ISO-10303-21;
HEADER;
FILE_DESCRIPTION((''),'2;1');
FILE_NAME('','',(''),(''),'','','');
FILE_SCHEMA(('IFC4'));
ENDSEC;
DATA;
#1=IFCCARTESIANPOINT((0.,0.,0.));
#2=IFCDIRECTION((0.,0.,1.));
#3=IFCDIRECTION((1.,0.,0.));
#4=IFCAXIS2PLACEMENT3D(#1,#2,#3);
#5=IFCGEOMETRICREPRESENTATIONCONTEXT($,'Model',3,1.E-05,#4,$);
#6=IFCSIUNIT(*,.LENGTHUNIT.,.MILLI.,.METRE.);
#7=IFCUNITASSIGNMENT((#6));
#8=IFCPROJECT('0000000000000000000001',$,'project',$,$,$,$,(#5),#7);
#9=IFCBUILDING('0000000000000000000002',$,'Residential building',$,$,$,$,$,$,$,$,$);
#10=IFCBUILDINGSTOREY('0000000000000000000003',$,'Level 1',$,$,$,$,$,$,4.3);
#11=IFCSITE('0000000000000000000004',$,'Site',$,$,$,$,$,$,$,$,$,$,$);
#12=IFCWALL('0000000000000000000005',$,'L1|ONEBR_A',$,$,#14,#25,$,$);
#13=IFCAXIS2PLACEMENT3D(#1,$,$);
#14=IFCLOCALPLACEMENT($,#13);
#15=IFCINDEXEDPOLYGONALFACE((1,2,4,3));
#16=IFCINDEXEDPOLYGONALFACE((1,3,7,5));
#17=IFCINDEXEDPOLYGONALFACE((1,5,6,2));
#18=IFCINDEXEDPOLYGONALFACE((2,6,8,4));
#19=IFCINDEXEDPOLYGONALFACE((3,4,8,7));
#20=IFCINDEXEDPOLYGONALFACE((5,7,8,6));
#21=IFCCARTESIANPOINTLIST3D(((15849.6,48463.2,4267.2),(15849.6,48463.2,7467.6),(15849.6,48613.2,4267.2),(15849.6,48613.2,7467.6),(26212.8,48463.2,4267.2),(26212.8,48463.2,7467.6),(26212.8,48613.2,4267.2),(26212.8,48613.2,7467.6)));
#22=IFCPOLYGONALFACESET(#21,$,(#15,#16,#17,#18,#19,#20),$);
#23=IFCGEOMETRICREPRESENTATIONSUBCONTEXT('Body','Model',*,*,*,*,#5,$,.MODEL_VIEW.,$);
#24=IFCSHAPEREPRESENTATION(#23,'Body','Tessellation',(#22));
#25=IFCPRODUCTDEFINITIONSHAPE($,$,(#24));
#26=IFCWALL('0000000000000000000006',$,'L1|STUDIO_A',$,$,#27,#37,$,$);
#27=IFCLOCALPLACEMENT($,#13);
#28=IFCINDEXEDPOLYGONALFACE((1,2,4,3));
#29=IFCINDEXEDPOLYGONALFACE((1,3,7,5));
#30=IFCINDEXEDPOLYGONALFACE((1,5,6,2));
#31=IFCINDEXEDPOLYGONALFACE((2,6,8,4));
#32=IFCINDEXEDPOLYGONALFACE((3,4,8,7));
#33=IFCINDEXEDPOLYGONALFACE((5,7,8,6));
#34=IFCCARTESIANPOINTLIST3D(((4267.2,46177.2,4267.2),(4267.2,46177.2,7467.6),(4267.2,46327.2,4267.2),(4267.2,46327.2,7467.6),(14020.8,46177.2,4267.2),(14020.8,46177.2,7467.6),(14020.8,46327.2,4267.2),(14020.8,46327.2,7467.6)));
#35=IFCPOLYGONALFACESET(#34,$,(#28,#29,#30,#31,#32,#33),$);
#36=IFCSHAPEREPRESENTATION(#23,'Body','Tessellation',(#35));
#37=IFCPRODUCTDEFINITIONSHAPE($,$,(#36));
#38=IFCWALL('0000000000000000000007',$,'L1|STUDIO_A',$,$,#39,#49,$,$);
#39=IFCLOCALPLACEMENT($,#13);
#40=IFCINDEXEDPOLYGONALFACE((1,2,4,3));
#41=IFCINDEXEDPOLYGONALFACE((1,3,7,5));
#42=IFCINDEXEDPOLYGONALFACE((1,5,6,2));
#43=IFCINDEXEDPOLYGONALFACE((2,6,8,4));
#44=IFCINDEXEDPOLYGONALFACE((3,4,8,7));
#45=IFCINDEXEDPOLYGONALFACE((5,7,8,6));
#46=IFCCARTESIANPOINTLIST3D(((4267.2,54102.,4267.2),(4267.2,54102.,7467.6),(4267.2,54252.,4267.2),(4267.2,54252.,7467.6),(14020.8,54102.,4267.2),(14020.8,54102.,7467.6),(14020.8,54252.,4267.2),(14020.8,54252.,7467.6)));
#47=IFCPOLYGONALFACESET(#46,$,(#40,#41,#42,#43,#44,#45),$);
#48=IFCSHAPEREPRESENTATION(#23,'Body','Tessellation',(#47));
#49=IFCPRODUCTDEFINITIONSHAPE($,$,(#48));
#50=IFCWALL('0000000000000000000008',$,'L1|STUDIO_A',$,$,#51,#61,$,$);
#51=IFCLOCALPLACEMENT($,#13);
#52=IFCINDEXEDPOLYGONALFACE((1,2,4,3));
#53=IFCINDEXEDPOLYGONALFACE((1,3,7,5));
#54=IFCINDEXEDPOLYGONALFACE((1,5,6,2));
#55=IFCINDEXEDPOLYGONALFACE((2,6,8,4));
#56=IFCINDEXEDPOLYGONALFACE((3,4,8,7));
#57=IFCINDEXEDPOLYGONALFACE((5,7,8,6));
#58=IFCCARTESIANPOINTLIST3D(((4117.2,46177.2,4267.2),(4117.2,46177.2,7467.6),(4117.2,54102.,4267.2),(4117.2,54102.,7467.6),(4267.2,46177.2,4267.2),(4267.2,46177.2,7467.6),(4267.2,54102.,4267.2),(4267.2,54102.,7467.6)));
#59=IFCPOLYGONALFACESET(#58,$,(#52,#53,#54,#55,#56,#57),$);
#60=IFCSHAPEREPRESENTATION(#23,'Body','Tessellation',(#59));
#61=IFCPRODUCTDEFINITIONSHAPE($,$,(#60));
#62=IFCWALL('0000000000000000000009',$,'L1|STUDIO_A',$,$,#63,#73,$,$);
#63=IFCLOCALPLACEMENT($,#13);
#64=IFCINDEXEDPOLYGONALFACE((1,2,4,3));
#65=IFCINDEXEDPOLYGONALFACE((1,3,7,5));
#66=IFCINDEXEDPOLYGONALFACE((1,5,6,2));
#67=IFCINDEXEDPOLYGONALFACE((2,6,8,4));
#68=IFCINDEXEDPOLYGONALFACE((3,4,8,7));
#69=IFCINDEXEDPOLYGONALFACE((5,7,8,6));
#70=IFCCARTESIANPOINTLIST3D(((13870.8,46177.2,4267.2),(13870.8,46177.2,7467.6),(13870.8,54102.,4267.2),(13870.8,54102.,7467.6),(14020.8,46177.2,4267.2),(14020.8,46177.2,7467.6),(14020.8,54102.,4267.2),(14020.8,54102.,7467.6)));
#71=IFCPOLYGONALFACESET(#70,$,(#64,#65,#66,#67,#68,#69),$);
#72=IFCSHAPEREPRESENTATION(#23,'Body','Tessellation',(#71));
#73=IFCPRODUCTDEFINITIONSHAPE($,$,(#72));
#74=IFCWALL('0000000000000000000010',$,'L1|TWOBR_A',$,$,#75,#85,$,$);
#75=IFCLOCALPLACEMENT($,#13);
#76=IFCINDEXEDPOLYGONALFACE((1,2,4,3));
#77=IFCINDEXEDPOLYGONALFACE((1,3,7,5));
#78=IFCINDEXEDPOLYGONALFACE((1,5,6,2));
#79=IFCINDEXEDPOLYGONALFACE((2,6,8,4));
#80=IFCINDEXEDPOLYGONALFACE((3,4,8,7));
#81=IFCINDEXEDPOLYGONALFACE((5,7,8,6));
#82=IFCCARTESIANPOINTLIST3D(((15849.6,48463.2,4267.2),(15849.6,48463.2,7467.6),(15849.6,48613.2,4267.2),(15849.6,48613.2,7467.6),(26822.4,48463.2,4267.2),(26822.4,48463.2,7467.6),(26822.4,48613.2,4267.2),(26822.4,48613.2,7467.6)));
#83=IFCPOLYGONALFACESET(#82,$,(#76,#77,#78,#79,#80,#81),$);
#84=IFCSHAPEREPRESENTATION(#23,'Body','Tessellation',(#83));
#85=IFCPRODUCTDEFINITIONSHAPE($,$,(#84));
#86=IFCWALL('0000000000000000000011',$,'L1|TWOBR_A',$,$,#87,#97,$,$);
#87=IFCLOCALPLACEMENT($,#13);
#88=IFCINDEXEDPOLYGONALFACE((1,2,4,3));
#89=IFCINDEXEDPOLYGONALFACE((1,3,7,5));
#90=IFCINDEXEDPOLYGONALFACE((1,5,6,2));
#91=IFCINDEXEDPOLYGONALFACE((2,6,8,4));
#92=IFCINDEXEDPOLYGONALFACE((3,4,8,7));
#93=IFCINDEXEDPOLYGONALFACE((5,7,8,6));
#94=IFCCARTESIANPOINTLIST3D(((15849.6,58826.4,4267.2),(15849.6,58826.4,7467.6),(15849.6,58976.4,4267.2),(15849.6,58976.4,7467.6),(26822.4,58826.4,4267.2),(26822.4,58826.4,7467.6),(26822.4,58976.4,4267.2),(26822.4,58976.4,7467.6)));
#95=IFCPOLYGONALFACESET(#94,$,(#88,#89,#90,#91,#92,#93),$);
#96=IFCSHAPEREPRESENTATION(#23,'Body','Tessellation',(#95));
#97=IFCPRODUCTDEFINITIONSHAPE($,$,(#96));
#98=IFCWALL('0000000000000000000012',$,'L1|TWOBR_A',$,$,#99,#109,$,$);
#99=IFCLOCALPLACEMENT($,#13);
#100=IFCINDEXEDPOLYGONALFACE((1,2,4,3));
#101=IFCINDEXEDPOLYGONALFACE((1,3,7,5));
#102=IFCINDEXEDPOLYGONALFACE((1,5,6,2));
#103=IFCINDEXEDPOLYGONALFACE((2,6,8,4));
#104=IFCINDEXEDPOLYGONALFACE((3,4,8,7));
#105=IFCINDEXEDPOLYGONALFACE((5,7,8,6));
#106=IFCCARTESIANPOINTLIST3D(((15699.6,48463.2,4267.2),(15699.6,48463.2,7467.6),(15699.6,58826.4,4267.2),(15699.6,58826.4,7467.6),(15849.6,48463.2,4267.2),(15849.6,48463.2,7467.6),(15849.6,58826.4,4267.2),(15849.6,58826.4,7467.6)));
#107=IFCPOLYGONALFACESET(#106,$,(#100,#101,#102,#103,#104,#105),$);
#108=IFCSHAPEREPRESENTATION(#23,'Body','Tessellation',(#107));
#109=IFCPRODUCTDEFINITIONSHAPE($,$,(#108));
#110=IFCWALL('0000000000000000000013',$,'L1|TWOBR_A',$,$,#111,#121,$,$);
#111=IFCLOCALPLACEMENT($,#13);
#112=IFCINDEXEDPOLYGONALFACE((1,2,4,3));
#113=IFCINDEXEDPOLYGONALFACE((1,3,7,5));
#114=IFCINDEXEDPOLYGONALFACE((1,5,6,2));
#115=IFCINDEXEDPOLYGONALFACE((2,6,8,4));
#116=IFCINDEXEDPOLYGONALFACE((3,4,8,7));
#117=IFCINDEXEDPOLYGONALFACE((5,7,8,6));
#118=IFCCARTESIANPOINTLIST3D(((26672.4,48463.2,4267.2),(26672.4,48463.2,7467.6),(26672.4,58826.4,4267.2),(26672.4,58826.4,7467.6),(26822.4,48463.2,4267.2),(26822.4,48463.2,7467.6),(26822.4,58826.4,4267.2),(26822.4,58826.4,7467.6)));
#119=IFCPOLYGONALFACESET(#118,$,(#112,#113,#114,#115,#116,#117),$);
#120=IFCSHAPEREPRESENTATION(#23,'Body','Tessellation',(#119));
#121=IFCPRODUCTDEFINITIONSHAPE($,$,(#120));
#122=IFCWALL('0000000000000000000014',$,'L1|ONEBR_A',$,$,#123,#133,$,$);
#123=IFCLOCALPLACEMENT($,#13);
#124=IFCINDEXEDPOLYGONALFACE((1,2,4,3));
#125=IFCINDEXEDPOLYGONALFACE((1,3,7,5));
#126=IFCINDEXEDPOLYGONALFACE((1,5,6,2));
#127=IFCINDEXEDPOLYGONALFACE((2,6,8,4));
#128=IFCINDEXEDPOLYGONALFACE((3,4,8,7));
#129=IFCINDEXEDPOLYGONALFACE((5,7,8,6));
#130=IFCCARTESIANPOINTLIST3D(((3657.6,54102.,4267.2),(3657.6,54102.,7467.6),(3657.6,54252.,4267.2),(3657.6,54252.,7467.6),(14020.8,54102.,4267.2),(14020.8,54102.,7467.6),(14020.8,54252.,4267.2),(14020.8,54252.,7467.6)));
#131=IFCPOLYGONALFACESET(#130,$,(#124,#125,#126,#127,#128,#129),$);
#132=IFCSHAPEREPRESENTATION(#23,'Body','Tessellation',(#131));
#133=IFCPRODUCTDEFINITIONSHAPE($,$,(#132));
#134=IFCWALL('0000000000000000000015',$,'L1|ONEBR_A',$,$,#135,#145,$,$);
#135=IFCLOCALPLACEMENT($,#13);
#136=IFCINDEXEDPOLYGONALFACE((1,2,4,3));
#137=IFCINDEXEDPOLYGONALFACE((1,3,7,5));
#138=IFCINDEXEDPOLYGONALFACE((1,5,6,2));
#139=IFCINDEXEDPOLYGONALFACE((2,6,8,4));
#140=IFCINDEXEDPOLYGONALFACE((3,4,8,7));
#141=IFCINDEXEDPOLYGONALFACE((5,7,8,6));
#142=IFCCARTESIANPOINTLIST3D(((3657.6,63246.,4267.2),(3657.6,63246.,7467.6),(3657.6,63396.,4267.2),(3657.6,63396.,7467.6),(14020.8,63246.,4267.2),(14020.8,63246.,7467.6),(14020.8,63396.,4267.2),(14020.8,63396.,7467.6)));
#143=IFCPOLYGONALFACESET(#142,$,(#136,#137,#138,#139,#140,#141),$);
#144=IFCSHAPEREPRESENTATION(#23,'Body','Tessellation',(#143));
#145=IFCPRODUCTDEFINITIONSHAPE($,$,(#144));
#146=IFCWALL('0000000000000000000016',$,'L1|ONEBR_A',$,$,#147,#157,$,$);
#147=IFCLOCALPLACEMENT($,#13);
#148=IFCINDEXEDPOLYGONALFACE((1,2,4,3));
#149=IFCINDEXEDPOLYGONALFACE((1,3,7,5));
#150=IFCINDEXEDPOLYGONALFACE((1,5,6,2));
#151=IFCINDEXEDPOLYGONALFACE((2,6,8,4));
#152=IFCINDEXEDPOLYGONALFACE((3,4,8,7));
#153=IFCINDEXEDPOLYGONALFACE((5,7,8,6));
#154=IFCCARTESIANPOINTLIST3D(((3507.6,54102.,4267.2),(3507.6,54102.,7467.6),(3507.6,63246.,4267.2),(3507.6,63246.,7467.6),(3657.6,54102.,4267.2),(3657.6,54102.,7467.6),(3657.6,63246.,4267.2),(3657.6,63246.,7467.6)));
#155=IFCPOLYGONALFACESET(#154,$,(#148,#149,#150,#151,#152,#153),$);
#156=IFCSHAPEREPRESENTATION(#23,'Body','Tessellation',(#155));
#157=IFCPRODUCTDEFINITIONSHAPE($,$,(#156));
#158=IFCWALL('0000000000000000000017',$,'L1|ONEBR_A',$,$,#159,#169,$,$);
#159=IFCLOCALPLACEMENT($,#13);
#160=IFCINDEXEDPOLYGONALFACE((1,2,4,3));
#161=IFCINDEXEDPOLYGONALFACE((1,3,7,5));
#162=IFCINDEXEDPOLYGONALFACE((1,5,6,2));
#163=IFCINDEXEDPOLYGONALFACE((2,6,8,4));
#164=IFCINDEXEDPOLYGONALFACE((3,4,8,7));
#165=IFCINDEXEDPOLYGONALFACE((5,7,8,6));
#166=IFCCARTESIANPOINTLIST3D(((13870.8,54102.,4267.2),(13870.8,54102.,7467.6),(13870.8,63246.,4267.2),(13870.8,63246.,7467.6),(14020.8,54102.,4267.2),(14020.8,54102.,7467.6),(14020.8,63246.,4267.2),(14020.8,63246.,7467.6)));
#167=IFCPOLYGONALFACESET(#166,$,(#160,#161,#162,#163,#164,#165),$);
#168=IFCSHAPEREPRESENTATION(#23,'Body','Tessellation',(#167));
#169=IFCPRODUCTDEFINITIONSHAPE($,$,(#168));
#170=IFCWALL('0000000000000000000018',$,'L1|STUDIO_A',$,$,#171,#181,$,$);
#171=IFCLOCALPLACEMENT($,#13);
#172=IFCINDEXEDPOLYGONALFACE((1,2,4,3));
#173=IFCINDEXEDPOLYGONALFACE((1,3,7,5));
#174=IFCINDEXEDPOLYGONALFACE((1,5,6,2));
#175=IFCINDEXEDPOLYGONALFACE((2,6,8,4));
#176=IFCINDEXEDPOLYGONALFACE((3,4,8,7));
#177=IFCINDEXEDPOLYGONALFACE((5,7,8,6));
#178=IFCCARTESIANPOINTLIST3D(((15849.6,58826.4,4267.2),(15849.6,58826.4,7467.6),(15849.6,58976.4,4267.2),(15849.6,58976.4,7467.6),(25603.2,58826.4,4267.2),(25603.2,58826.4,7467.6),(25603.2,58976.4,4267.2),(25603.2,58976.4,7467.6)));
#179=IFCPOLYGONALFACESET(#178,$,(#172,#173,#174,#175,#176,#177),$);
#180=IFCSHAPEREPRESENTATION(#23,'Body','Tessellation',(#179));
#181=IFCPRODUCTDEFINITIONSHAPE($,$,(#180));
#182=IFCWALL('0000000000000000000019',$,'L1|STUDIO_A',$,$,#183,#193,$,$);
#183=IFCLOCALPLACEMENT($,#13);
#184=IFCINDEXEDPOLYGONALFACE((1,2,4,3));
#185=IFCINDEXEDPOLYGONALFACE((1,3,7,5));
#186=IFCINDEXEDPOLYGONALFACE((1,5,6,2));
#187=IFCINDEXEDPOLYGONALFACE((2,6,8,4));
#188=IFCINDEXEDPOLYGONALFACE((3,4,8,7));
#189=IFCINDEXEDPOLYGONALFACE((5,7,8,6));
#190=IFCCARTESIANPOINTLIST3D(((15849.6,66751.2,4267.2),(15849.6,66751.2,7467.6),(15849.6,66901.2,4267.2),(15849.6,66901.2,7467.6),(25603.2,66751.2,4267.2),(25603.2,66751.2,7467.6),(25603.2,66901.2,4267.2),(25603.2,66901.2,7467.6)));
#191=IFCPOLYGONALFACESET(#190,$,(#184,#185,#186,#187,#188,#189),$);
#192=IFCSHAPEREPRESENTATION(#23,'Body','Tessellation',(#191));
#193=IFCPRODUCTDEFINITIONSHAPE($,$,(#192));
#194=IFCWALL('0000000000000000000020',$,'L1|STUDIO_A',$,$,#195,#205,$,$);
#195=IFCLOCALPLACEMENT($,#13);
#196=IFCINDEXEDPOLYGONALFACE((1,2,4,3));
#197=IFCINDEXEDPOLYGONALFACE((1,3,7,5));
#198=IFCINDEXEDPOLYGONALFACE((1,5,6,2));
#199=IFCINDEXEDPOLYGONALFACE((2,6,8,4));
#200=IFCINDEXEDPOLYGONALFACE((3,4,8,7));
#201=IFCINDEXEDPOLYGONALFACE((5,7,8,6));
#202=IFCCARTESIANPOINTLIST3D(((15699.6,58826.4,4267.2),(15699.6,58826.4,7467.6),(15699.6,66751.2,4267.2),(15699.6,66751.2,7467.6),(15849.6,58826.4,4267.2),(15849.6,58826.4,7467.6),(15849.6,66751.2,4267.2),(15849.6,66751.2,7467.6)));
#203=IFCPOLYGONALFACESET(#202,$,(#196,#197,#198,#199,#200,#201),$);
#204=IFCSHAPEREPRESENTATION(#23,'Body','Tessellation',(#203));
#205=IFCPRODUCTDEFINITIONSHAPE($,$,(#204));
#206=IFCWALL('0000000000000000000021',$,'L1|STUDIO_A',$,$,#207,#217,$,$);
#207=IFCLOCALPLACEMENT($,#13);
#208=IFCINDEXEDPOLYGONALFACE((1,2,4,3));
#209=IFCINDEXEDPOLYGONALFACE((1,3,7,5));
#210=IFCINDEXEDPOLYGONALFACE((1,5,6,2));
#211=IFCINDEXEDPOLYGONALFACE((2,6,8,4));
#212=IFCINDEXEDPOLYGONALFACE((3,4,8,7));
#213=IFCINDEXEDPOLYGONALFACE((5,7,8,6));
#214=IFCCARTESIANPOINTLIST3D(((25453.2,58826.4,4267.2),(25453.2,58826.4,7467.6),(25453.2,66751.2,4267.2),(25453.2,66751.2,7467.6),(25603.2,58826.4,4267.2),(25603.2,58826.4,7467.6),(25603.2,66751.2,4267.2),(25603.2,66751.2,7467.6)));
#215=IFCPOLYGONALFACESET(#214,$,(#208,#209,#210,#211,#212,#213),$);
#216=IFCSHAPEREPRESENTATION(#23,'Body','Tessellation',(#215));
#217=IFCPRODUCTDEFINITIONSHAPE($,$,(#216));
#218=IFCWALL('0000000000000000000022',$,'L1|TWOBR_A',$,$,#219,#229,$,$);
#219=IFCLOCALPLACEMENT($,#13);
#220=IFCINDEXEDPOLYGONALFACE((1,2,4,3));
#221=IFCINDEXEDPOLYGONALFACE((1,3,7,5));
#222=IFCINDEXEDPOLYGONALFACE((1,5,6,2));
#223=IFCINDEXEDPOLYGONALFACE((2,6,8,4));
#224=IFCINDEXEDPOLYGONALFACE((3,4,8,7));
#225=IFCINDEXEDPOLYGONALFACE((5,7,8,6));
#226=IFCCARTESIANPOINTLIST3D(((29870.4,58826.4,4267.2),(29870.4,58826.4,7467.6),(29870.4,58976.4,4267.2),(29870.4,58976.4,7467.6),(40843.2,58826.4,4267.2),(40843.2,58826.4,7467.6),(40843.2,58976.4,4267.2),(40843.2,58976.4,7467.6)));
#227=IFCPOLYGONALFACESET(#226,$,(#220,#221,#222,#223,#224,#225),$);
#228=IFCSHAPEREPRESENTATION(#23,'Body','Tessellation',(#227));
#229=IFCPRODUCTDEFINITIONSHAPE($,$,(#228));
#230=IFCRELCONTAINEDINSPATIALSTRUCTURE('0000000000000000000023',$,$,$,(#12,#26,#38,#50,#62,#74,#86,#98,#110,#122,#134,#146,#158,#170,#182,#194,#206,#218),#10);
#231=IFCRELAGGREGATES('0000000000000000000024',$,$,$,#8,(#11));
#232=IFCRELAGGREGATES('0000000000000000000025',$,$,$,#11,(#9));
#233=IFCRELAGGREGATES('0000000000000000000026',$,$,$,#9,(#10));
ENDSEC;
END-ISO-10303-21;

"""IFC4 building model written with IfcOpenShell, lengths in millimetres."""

from ifc_helpers import new_model, si_unit, frame, origin_with_axes, place, context, subcontext, project, spatial, indexed_curve, outline, extrude, element, save


model = new_model("IFC4")

# Units and contexts
model_context = context("Model", 3, precision=1e-05, world=origin_with_axes())
body_context = subcontext(model_context, "Body", "Model", "MODEL_VIEW")
ifc_project = project(units=[si_unit("LENGTHUNIT", "METRE", prefix="MILLI")], contexts=[model_context])

# Site, building, storey
site = spatial("IfcSite", under=ifc_project, Name="Site")
building = spatial("IfcBuilding", under=site, Name="Residential building")
storey = spatial("IfcBuildingStorey", under=building, Name="Level 1", Elevation=4.3)

# Walls
wall_1_placement = place(None, frame((15849.6, 48463.2, 4267.2), z_axis=(0.0, 0.0, 1.0), x_axis=(1.0, 0.0, 0.0)))
element("IfcWall", 1, at=wall_1_placement, inside=storey, Name="L1|ONEBR_A", context=body_context, shape_type="SweptSolid", body=[
    extrude(outline(indexed_curve([(0.0, 0.0), (0.0, 150.0), (10363.2, 150.0), (10363.2, 0.0), (0.0, 0.0)], self_intersect=False)), origin_with_axes(), (0.0, 0.0, 1.0), 3200.4),
])
for number, where, z_axis, x_axis, name in (
    (2, (4267.2, 46177.2, 4267.2), (0.0, 0.0, 1.0), (1.0, 0.0, 0.0), "L1|STUDIO_A"),
    (3, (4267.2, 54102.0, 4267.2), (0.0, 0.0, 1.0), (1.0, 0.0, 0.0), "L1|STUDIO_A"),
):
    element("IfcWall", number, at=place(None, frame(where, z_axis=z_axis, x_axis=x_axis)), inside=storey, Name=name, context=body_context, shape_type="SweptSolid", body=[
        extrude(outline(indexed_curve([(0.0, 0.0), (0.0, 150.0), (9753.6, 150.0), (9753.6, 0.0), (0.0, 0.0)], self_intersect=False)), origin_with_axes(), (0.0, 0.0, 1.0), 3200.4),
    ])
for number, where, z_axis, x_axis, name in (
    (4, (4267.2, 46177.2, 4267.2), (0.0, 0.0, 1.0), (0.0, 1.0, 0.0), "L1|STUDIO_A"),
    (5, (14020.8, 46177.2, 4267.2), (0.0, 0.0, 1.0), (0.0, 1.0, 0.0), "L1|STUDIO_A"),
):
    element("IfcWall", number, at=place(None, frame(where, z_axis=z_axis, x_axis=x_axis)), inside=storey, Name=name, context=body_context, shape_type="SweptSolid", body=[
        extrude(outline(indexed_curve([(0.0, 0.0), (0.0, 150.0), (7924.8, 150.0), (7924.8, 0.0), (0.0, 0.0)], self_intersect=False)), origin_with_axes(), (0.0, 0.0, 1.0), 3200.4),
    ])
for number, where, z_axis, x_axis, name in (
    (6, (15849.6, 48463.2, 4267.2), (0.0, 0.0, 1.0), (1.0, 0.0, 0.0), "L1|TWOBR_A"),
    (7, (15849.6, 58826.4, 4267.2), (0.0, 0.0, 1.0), (1.0, 0.0, 0.0), "L1|TWOBR_A"),
):
    element("IfcWall", number, at=place(None, frame(where, z_axis=z_axis, x_axis=x_axis)), inside=storey, Name=name, context=body_context, shape_type="SweptSolid", body=[
        extrude(outline(indexed_curve([(0.0, 0.0), (0.0, 150.0), (10972.8, 150.0), (10972.8, 0.0), (0.0, 0.0)], self_intersect=False)), origin_with_axes(), (0.0, 0.0, 1.0), 3200.4),
    ])
for number, where, z_axis, x_axis, name in (
    (8, (15849.6, 48463.2, 4267.2), (0.0, 0.0, 1.0), (0.0, 1.0, 0.0), "L1|TWOBR_A"),
    (9, (26822.4, 48463.2, 4267.2), (0.0, 0.0, 1.0), (0.0, 1.0, 0.0), "L1|TWOBR_A"),
    (10, (3657.6, 54102.0, 4267.2), (0.0, 0.0, 1.0), (1.0, 0.0, 0.0), "L1|ONEBR_A"),
    (11, (3657.6, 63246.0, 4267.2), (0.0, 0.0, 1.0), (1.0, 0.0, 0.0), "L1|ONEBR_A"),
):
    element("IfcWall", number, at=place(None, frame(where, z_axis=z_axis, x_axis=x_axis)), inside=storey, Name=name, context=body_context, shape_type="SweptSolid", body=[
        extrude(outline(indexed_curve([(0.0, 0.0), (0.0, 150.0), (10363.2, 150.0), (10363.2, 0.0), (0.0, 0.0)], self_intersect=False)), origin_with_axes(), (0.0, 0.0, 1.0), 3200.4),
    ])
for number, where, z_axis, x_axis, name in (
    (12, (3657.6, 54102.0, 4267.2), (0.0, 0.0, 1.0), (0.0, 1.0, 0.0), "L1|ONEBR_A"),
    (13, (14020.8, 54102.0, 4267.2), (0.0, 0.0, 1.0), (0.0, 1.0, 0.0), "L1|ONEBR_A"),
):
    element("IfcWall", number, at=place(None, frame(where, z_axis=z_axis, x_axis=x_axis)), inside=storey, Name=name, context=body_context, shape_type="SweptSolid", body=[
        extrude(outline(indexed_curve([(0.0, 0.0), (0.0, 150.0), (9144.0, 150.0), (9144.0, 0.0), (0.0, 0.0)], self_intersect=False)), origin_with_axes(), (0.0, 0.0, 1.0), 3200.4),
    ])
for number, where, z_axis, x_axis, name in (
    (14, (15849.6, 58826.4, 4267.2), (0.0, 0.0, 1.0), (1.0, 0.0, 0.0), "L1|STUDIO_A"),
    (15, (15849.6, 66751.2, 4267.2), (0.0, 0.0, 1.0), (1.0, 0.0, 0.0), "L1|STUDIO_A"),
):
    element("IfcWall", number, at=place(None, frame(where, z_axis=z_axis, x_axis=x_axis)), inside=storey, Name=name, context=body_context, shape_type="SweptSolid", body=[
        extrude(outline(indexed_curve([(0.0, 0.0), (0.0, 150.0), (9753.6, 150.0), (9753.6, 0.0), (0.0, 0.0)], self_intersect=False)), origin_with_axes(), (0.0, 0.0, 1.0), 3200.4),
    ])
for number, where, z_axis, x_axis, name in (
    (16, (15849.6, 58826.4, 4267.2), (0.0, 0.0, 1.0), (0.0, 1.0, 0.0), "L1|STUDIO_A"),
    (17, (25603.2, 58826.4, 4267.2), (0.0, 0.0, 1.0), (0.0, 1.0, 0.0), "L1|STUDIO_A"),
):
    element("IfcWall", number, at=place(None, frame(where, z_axis=z_axis, x_axis=x_axis)), inside=storey, Name=name, context=body_context, shape_type="SweptSolid", body=[
        extrude(outline(indexed_curve([(0.0, 0.0), (0.0, 150.0), (7924.8, 150.0), (7924.8, 0.0), (0.0, 0.0)], self_intersect=False)), origin_with_axes(), (0.0, 0.0, 1.0), 3200.4),
    ])
for number, where, z_axis, x_axis, name in (
    (18, (29870.4, 58826.4, 4267.2), (0.0, 0.0, 1.0), (1.0, 0.0, 0.0), "L1|TWOBR_A"),
):
    element("IfcWall", number, at=place(None, frame(where, z_axis=z_axis, x_axis=x_axis)), inside=storey, Name=name, context=body_context, shape_type="SweptSolid", body=[
        extrude(outline(indexed_curve([(0.0, 0.0), (0.0, 150.0), (10972.8, 150.0), (10972.8, 0.0), (0.0, 0.0)], self_intersect=False)), origin_with_axes(), (0.0, 0.0, 1.0), 3200.4),
    ])

save(model, "model.ifc")
